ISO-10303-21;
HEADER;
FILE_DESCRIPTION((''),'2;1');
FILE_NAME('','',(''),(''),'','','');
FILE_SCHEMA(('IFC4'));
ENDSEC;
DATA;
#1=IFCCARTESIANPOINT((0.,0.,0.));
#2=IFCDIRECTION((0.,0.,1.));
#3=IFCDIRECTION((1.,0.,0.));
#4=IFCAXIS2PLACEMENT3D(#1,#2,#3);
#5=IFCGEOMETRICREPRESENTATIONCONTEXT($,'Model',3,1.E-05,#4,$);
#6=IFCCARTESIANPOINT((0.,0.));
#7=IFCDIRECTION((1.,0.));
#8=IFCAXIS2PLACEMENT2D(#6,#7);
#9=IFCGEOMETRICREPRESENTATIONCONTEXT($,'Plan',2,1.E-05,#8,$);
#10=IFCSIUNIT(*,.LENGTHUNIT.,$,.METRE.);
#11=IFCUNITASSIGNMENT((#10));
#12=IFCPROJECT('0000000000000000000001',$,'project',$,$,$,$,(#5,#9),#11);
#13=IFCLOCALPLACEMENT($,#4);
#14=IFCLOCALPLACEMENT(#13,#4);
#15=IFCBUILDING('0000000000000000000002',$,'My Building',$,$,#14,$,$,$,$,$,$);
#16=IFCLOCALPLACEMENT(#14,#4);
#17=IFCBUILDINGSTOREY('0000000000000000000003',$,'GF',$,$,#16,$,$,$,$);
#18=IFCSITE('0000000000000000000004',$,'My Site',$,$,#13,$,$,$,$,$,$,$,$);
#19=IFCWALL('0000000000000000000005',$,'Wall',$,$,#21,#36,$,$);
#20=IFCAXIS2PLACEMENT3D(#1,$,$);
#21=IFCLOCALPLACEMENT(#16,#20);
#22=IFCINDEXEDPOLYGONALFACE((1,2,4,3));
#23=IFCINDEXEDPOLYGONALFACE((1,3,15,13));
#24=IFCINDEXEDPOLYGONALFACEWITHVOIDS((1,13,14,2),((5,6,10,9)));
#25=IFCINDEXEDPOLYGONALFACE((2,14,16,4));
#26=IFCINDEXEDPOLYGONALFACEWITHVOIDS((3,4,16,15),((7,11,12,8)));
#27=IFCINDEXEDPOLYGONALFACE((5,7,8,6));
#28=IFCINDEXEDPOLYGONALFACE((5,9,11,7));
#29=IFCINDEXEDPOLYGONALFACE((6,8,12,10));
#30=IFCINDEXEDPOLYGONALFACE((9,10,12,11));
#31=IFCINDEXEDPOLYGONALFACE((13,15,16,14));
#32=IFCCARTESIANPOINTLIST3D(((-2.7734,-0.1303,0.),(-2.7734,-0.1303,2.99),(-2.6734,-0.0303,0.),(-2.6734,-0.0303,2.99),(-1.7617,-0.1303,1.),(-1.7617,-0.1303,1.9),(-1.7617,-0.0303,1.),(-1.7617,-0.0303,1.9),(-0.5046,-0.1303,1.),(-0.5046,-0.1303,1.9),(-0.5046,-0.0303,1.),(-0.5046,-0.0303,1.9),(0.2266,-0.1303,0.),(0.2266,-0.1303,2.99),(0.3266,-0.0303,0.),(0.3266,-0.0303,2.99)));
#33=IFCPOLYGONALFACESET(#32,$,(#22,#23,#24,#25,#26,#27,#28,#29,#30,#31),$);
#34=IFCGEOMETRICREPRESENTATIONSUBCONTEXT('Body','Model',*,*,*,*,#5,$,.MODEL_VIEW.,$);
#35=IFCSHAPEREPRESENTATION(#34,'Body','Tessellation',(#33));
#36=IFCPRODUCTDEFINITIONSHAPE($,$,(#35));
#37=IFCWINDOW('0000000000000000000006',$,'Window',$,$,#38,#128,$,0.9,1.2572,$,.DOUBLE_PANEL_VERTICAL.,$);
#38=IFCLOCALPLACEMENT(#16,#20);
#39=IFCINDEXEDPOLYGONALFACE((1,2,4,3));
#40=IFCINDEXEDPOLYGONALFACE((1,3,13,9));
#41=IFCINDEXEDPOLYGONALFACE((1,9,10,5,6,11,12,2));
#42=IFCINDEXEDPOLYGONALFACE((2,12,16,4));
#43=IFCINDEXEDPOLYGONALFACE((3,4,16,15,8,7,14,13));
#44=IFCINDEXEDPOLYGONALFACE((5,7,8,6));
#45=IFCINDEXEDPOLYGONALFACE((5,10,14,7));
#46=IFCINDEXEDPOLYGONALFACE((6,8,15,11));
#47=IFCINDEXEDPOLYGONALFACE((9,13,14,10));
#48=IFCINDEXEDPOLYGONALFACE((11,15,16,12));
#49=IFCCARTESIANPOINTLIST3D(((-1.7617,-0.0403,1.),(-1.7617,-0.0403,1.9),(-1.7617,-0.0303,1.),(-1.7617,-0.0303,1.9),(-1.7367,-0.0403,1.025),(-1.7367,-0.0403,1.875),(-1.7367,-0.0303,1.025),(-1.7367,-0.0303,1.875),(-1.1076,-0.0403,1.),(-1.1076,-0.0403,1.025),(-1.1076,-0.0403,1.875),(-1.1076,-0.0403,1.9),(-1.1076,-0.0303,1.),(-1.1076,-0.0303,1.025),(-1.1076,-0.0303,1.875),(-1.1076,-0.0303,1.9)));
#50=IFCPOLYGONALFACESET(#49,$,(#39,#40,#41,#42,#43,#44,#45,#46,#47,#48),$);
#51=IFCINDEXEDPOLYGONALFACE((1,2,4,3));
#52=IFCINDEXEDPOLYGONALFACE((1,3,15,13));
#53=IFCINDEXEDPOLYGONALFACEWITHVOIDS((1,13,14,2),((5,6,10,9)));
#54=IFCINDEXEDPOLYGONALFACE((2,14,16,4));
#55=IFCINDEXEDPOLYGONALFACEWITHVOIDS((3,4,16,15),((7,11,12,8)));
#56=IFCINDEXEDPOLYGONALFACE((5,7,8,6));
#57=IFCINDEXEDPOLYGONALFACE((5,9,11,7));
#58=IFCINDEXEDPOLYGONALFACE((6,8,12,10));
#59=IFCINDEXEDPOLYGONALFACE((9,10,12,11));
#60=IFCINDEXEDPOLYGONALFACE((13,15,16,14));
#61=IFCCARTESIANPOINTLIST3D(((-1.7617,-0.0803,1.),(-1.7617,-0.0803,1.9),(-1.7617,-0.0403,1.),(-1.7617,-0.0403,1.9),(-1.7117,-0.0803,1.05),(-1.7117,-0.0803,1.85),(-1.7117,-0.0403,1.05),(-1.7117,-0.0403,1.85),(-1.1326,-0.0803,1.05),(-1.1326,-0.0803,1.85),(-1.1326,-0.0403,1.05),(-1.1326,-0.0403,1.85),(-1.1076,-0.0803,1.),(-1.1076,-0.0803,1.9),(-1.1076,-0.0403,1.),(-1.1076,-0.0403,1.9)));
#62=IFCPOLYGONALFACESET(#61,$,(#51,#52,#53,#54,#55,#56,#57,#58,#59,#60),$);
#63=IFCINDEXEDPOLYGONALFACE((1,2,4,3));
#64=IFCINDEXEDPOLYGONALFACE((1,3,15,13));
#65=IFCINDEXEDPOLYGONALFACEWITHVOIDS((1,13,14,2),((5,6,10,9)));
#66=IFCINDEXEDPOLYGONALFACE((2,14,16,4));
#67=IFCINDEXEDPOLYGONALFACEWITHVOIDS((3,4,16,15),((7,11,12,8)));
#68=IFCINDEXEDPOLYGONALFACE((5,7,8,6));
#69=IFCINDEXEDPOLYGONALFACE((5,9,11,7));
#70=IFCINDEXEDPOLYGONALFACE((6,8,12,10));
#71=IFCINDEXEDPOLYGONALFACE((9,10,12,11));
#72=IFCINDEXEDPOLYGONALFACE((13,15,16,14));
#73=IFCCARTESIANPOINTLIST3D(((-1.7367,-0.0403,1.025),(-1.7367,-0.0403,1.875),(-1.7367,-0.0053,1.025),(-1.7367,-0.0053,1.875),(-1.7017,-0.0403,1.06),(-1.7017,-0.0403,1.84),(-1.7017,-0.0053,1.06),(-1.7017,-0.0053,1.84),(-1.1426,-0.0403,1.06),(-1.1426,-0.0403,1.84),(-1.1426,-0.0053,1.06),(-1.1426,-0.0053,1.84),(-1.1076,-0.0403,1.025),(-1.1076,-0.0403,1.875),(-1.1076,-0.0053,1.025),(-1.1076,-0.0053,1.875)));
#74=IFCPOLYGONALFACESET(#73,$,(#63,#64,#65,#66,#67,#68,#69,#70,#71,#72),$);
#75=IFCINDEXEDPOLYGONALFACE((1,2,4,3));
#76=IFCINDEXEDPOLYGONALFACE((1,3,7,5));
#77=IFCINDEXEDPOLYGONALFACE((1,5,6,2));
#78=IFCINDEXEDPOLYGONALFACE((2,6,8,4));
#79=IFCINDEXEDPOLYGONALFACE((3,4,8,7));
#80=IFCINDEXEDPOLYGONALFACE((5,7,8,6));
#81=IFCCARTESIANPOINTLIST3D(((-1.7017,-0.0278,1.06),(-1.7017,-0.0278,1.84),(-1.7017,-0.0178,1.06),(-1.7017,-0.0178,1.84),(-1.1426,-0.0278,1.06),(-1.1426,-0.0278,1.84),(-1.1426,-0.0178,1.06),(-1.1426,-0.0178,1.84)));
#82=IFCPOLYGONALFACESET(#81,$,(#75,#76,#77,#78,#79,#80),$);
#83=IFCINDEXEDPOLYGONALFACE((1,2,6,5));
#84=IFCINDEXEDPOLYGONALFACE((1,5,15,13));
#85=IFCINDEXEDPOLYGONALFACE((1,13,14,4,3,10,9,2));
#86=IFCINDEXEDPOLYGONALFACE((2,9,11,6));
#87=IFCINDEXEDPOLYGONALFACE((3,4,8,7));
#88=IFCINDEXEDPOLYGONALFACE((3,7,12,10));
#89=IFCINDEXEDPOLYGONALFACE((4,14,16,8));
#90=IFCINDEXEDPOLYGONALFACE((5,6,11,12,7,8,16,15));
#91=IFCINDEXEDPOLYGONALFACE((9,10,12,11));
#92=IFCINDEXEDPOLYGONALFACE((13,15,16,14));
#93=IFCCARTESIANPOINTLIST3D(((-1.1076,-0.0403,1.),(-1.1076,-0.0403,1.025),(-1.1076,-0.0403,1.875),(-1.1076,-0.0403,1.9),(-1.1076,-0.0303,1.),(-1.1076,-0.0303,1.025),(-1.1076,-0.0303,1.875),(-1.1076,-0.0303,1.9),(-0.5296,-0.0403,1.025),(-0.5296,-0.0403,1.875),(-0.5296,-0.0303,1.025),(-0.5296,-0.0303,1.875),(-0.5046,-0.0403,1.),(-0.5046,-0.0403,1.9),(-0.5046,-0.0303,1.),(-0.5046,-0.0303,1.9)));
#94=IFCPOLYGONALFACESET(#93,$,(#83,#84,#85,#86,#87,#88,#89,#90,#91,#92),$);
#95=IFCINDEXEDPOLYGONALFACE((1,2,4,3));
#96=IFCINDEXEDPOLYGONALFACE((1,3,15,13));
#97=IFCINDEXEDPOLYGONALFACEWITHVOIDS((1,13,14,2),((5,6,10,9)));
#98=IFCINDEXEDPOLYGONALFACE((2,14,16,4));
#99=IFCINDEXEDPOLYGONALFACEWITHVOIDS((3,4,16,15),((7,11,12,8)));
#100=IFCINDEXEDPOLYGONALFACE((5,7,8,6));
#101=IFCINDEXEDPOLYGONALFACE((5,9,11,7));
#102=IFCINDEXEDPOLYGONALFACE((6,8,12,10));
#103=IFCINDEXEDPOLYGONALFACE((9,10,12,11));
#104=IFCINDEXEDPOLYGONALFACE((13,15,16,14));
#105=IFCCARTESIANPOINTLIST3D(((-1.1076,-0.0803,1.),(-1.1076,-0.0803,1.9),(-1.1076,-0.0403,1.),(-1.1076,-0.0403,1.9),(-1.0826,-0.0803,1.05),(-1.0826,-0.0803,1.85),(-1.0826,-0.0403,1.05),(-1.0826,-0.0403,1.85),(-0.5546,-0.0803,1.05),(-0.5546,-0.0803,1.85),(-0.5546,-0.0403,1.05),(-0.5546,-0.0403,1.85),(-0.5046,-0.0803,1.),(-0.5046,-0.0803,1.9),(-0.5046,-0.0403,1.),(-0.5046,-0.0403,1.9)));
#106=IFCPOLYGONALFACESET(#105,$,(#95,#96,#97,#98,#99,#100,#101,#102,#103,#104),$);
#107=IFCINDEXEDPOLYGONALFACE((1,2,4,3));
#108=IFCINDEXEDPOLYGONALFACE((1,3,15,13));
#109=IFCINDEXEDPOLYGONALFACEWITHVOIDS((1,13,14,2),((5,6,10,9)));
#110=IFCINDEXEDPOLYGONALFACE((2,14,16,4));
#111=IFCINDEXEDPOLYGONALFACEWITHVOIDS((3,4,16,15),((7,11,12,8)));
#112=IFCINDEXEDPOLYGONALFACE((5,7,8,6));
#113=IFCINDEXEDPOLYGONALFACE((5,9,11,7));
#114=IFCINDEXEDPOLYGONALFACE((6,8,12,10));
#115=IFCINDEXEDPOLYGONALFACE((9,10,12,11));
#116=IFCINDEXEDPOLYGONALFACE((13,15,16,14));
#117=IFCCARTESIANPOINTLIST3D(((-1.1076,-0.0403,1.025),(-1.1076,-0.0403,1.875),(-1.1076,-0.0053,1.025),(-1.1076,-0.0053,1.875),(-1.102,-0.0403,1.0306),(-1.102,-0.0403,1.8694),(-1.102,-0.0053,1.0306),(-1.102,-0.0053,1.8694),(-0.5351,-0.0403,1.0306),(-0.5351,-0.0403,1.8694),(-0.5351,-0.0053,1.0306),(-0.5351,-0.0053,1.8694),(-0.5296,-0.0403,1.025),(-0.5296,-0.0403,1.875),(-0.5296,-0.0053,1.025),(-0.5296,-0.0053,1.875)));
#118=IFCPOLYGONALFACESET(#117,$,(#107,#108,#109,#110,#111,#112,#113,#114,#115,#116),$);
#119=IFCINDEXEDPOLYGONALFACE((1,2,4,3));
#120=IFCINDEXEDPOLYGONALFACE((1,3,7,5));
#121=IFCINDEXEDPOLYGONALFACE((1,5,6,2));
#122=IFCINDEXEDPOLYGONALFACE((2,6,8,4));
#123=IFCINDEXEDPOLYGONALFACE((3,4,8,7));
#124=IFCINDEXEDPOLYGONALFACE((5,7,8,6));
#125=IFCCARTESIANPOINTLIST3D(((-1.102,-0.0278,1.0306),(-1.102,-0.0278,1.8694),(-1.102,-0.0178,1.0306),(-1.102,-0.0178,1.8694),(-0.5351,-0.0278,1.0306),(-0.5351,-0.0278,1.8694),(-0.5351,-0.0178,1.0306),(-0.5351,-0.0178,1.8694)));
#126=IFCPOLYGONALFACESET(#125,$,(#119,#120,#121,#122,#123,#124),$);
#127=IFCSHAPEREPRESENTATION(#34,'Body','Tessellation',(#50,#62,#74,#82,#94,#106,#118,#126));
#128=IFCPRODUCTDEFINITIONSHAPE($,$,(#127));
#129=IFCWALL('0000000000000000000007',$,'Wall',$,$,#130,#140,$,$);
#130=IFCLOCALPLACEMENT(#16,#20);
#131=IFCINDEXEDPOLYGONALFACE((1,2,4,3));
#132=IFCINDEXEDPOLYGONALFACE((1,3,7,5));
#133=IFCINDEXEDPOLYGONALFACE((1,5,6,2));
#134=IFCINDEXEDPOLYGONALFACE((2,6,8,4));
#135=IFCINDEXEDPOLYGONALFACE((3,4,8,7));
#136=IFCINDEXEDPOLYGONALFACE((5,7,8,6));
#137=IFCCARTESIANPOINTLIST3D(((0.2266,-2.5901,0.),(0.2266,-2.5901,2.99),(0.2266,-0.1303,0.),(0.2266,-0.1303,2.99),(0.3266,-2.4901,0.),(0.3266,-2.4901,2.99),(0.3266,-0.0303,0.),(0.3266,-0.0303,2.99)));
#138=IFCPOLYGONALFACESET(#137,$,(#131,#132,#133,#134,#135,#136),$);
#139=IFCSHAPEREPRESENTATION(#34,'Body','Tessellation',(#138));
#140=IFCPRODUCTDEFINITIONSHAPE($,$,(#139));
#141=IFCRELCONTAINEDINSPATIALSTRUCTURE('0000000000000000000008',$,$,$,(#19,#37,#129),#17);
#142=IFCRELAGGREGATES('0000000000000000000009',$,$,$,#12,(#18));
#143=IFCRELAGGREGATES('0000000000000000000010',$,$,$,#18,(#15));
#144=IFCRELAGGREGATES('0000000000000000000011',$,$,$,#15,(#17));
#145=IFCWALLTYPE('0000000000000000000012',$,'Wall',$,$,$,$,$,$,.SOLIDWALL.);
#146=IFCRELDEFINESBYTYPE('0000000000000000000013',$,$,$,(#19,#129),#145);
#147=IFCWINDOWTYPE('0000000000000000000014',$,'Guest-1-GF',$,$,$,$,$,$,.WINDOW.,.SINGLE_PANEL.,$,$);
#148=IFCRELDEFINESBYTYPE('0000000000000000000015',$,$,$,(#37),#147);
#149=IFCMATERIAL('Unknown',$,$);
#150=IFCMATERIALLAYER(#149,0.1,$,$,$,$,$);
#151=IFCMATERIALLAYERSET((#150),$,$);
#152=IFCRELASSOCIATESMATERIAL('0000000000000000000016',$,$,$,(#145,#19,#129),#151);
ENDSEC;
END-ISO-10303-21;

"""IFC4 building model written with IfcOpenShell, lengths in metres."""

from ifc_helpers import new_model, entity, si_unit, frame, origin_with_axes, origin_2d_with_axis, place, context, subcontext, project, spatial, line, indexed_curve, outline, extrude, shape, source, transform, mapped, material, layer, layer_set, layer_usage, type_object, type_shapes, element, fill, save


model = new_model("IFC4")

# Units and contexts
model_context = context("Model", 3, precision=1e-05, world=origin_with_axes())
plan_context = context("Plan", 2, precision=1e-05, world=origin_2d_with_axis())
body_context_1 = subcontext(model_context, "Body", "Model", "MODEL_VIEW")
body_context_2 = subcontext(plan_context, "Body", "Plan", "PLAN_VIEW")
ifc_project = project(units=[si_unit("LENGTHUNIT", "METRE")], contexts=[model_context, plan_context])

# Site, building, storey
site_placement = place(None, origin_with_axes())
site = spatial("IfcSite", under=ifc_project, at=site_placement, Name="My Site")
building_placement = place(site_placement, origin_with_axes())
building = spatial("IfcBuilding", under=site, at=building_placement, Name="My Building")
storey_placement = place(building_placement, origin_with_axes())
storey = spatial("IfcBuildingStorey", under=building, at=storey_placement, Name="GF")

# Shared definitions
ifc_material_1 = material(Name="Unknown")

# Shared definitions
ifc_layer_1 = layer(ifc_material_1, 0.1)
ifc_layer_set_1 = layer_set([ifc_layer_1])
wall_type = type_object("IfcWallType", Name="Wall", PredefinedType="SOLIDWALL", material=ifc_layer_set_1)

# Wall, opening, window
ifc_layer_usage_1 = layer_usage(ifc_layer_set_1, "AXIS2", "POSITIVE", 0.0)
wall_1_placement = place(storey_placement, frame((-2.7734, -0.1303, 0.0), z_axis=(0.0, 0.0, 1.0), x_axis=(1.0, 0.0, 0.0)))
wall_1 = element("IfcWall", 1, at=wall_1_placement, inside=storey, type_object=wall_type, material=ifc_layer_usage_1, Name="Wall", context=body_context_1, shape_type="SweptSolid", body=[
    extrude(outline(indexed_curve([(0.0, 0.0), (0.1, 0.1), (3.1, 0.1), (3.0, 0.0)], segments=[line(1, 2, 3, 4, 1)])), origin_with_axes(), (0.0, 0.0, 1.0), 2.99),
])
shared_shape_1 = source(origin_with_axes(), body_context_1, "Body", "SweptSolid", [
    extrude(outline(indexed_curve([(0.0, 0.0), (1.2572, 0.0), (1.2572, 0.9), (0.0, 0.9)], segments=[line(1, 2, 3, 4, 1)])), frame((0.0, -0.6, 0.0), z_axis=(0.0, -1.0, 0.0), x_axis=(1.0, 0.0, 0.0)), (0.0, 0.0, -1.0), 1.2),
])
opening_1_placement = place(wall_1_placement, frame((1.0116, 0.0, 1.0), z_axis=(0.0, 0.0, 1.0), x_axis=(1.0, 0.0, 0.0)))
opening_1 = element("IfcOpeningElement", 2, at=opening_1_placement, cuts=wall_1, PredefinedType="OPENING", context=body_context_1, shape_type="MappedRepresentation", body=[
    mapped(shared_shape_1, transform((0.0, 0.0, 0.0), x_axis=(1.0, 0.0, 0.0), y_axis=(0.0, 1.0, 0.0), z_axis=(0.0, 0.0, 1.0), scale=1.0)),
])
window_type_1 = type_object("IfcWindowType", Name="Guest-1-GF", PartitioningType="SINGLE_PANEL", PredefinedType="WINDOW")
shared_shape_2 = source(origin_with_axes(), body_context_1, "Body", "SweptSolid", [
    extrude(outline(indexed_curve([(0.6541, 0.0), (0.0, 0.0), (0.0, 0.9), (0.6541, 0.9), (0.6541, 0.875), (0.025, 0.875), (0.025, 0.025), (0.6541, 0.025)], segments=[line(1, 2, 3, 4, 5, 6, 7, 8, 1)])), frame((0.0, 0.09, 0.0), z_axis=(0.0, -1.0, 0.0), x_axis=(1.0, 0.0, 0.0)), (0.0, 0.0, -1.0), 0.01),
    extrude(outline(indexed_curve([(0.0, 0.0), (0.6541, 0.0), (0.6541, 0.9), (0.0, 0.9)], segments=[line(1, 2, 3, 4, 1)]), holes=[indexed_curve([(0.05, 0.05), (0.6291, 0.05), (0.6291, 0.85), (0.05, 0.85)], segments=[line(1, 2, 3, 4, 1)])]), frame((0.0, 0.05, 0.0), z_axis=(0.0, -1.0, 0.0), x_axis=(1.0, 0.0, 0.0)), (0.0, 0.0, -1.0), 0.04),
    extrude(outline(indexed_curve([(0.0, 0.0), (0.6291, 0.0), (0.6291, 0.85), (0.0, 0.85)], segments=[line(1, 2, 3, 4, 1)]), holes=[indexed_curve([(0.035, 0.035), (0.5941, 0.035), (0.5941, 0.815), (0.035, 0.815)], segments=[line(1, 2, 3, 4, 1)])]), frame((0.025, 0.09, 0.025), z_axis=(0.0, -1.0, 0.0), x_axis=(1.0, 0.0, 0.0)), (0.0, 0.0, -1.0), 0.035),
    extrude(outline(indexed_curve([(0.035, 0.035), (0.5941, 0.035), (0.5941, 0.815), (0.035, 0.815)], segments=[line(1, 2, 3, 4, 1)])), frame((0.025, 0.1025, 0.025), z_axis=(0.0, -1.0, 0.0), x_axis=(1.0, 0.0, 0.0)), (0.0, 0.0, -1.0), 0.01),
    extrude(outline(indexed_curve([(0.0, 0.9), (0.603, 0.9), (0.603, 0.0), (0.0, 0.0), (0.0, 0.025), (0.578, 0.025), (0.578, 0.875), (0.0, 0.875)], segments=[line(1, 2, 3, 4, 5, 6, 7, 8, 1)])), frame((0.6541, 0.09, 0.0), z_axis=(0.0, -1.0, 0.0), x_axis=(1.0, 0.0, 0.0)), (0.0, 0.0, -1.0), 0.01),
    extrude(outline(indexed_curve([(0.0, 0.0), (0.603, 0.0), (0.603, 0.9), (0.0, 0.9)], segments=[line(1, 2, 3, 4, 1)]), holes=[indexed_curve([(0.025, 0.05), (0.553, 0.05), (0.553, 0.85), (0.025, 0.85)], segments=[line(1, 2, 3, 4, 1)])]), frame((0.6541, 0.05, 0.0), z_axis=(0.0, -1.0, 0.0), x_axis=(1.0, 0.0, 0.0)), (0.0, 0.0, -1.0), 0.04),
    extrude(outline(indexed_curve([(0.0, 0.0), (0.578, 0.0), (0.578, 0.85), (0.0, 0.85)], segments=[line(1, 2, 3, 4, 1)]), holes=[indexed_curve([(0.0056, 0.0056), (0.5725, 0.0056), (0.5725, 0.8444), (0.0056, 0.8444)], segments=[line(1, 2, 3, 4, 1)])]), frame((0.6541, 0.09, 0.025), z_axis=(0.0, -1.0, 0.0), x_axis=(1.0, 0.0, 0.0)), (0.0, 0.0, -1.0), 0.035),
    extrude(outline(indexed_curve([(0.0056, 0.0056), (0.5725, 0.0056), (0.5725, 0.8444), (0.0056, 0.8444)], segments=[line(1, 2, 3, 4, 1)])), frame((0.6541, 0.1025, 0.025), z_axis=(0.0, -1.0, 0.0), x_axis=(1.0, 0.0, 0.0)), (0.0, 0.0, -1.0), 0.01),
])
shared_shape_3 = source(origin_with_axes(), body_context_2, "Body", "Curve2D", [
    entity("IfcIndexedPolyCurve", entity("IfcCartesianPointList2D", [[0.05, 0.05], [0.6291, 0.05]])),
    entity("IfcIndexedPolyCurve", entity("IfcCartesianPointList2D", [[0.0, 0.1], [0.025, 0.1], [0.025, 0.09], [0.05, 0.09], [0.05, 0.05], [0.0, 0.05]]), [entity("IfcLineIndex", [1, 2, 3, 4, 5, 6, 1])]),
    entity("IfcIndexedPolyCurve", entity("IfcCartesianPointList2D", [[0.6541, 0.1], [0.6541, 0.1], [0.6541, 0.09], [0.6291, 0.09], [0.6291, 0.05], [0.6541, 0.05]])),
    entity("IfcIndexedPolyCurve", entity("IfcCartesianPointList2D", [[0.025, 0.09], [0.06, 0.09], [0.06, 0.125], [0.025, 0.125]]), [entity("IfcLineIndex", [1, 2, 3, 4, 1])]),
    entity("IfcIndexedPolyCurve", entity("IfcCartesianPointList2D", [[0.6541, 0.09], [0.6191, 0.09], [0.6191, 0.125], [0.6541, 0.125]]), [entity("IfcLineIndex", [1, 2, 3, 4, 1])]),
    entity("IfcIndexedPolyCurve", entity("IfcCartesianPointList2D", [[0.06, 0.09], [0.6191, 0.09]])),
    entity("IfcIndexedPolyCurve", entity("IfcCartesianPointList2D", [[0.06, 0.125], [0.6191, 0.125]])),
    entity("IfcIndexedPolyCurve", entity("IfcCartesianPointList2D", [[0.06, 0.1075], [0.6191, 0.1075]])),
    entity("IfcIndexedPolyCurve", entity("IfcCartesianPointList2D", [[0.6791, 0.05], [1.2072, 0.05]])),
    entity("IfcIndexedPolyCurve", entity("IfcCartesianPointList2D", [[0.6541, 0.1], [0.6541, 0.1], [0.6541, 0.09], [0.6791, 0.09], [0.6791, 0.05], [0.6541, 0.05]])),
    entity("IfcIndexedPolyCurve", entity("IfcCartesianPointList2D", [[1.2572, 0.1], [1.2322, 0.1], [1.2322, 0.09], [1.2072, 0.09], [1.2072, 0.05], [1.2572, 0.05]]), [entity("IfcLineIndex", [1, 2, 3, 4, 5, 6, 1])]),
    entity("IfcIndexedPolyCurve", entity("IfcCartesianPointList2D", [[0.6541, 0.09], [0.6597, 0.09], [0.6597, 0.125], [0.6541, 0.125]]), [entity("IfcLineIndex", [1, 2, 3, 4, 1])]),
    entity("IfcIndexedPolyCurve", entity("IfcCartesianPointList2D", [[1.2322, 0.09], [1.2266, 0.09], [1.2266, 0.125], [1.2322, 0.125]]), [entity("IfcLineIndex", [1, 2, 3, 4, 1])]),
    entity("IfcIndexedPolyCurve", entity("IfcCartesianPointList2D", [[0.6597, 0.09], [1.2266, 0.09]])),
    entity("IfcIndexedPolyCurve", entity("IfcCartesianPointList2D", [[0.6597, 0.125], [1.2266, 0.125]])),
    entity("IfcIndexedPolyCurve", entity("IfcCartesianPointList2D", [[0.6597, 0.1075], [1.2266, 0.1075]])),
])
type_shapes(window_type_1, [shared_shape_2, shared_shape_3])
window_1_placement = place(opening_1_placement, frame((0.0, 0.0, 0.0), z_axis=(0.0, 0.0, 1.0), x_axis=(1.0, 0.0, 0.0)))
window_1 = element("IfcWindow", 3, at=window_1_placement, inside=storey, type_object=window_type_1, Name="Window", OverallHeight=0.9, OverallWidth=1.2572, PartitioningType="DOUBLE_PANEL_VERTICAL", shapes=[
    shape(body_context_1, "Body", "MappedRepresentation", [mapped(shared_shape_2, transform((0.0, 0.0, 0.0), x_axis=(1.0, 0.0, 0.0), y_axis=(0.0, 1.0, 0.0), z_axis=(0.0, 0.0, 1.0), scale=1.0))]),
    shape(body_context_2, "Body", "MappedRepresentation", [mapped(shared_shape_3, transform((0.0, 0.0, 0.0), x_axis=(1.0, 0.0, 0.0), y_axis=(0.0, 1.0, 0.0), z_axis=(0.0, 0.0, 1.0), scale=1.0))]),
])
fill(opening_1, window_1)

# Wall
ifc_layer_usage_2 = layer_usage(ifc_layer_set_1, "AXIS2", "POSITIVE", 0.0)
wall_2_placement = place(storey_placement, frame((0.2266, -0.1303, 0.0), z_axis=(0.0, 0.0, 1.0), x_axis=(0.0, -1.0, 0.0)))
element("IfcWall", 4, at=wall_2_placement, inside=storey, type_object=wall_type, material=ifc_layer_usage_2, Name="Wall", context=body_context_1, shape_type="SweptSolid", body=[
    extrude(outline(indexed_curve([(0.0, 0.0), (-0.1, 0.1), (2.3598, 0.1), (2.4598, 0.0)], segments=[line(1, 2, 3, 4, 1)])), origin_with_axes(), (0.0, 0.0, 1.0), 2.99),
])

save(model, "model.ifc")
